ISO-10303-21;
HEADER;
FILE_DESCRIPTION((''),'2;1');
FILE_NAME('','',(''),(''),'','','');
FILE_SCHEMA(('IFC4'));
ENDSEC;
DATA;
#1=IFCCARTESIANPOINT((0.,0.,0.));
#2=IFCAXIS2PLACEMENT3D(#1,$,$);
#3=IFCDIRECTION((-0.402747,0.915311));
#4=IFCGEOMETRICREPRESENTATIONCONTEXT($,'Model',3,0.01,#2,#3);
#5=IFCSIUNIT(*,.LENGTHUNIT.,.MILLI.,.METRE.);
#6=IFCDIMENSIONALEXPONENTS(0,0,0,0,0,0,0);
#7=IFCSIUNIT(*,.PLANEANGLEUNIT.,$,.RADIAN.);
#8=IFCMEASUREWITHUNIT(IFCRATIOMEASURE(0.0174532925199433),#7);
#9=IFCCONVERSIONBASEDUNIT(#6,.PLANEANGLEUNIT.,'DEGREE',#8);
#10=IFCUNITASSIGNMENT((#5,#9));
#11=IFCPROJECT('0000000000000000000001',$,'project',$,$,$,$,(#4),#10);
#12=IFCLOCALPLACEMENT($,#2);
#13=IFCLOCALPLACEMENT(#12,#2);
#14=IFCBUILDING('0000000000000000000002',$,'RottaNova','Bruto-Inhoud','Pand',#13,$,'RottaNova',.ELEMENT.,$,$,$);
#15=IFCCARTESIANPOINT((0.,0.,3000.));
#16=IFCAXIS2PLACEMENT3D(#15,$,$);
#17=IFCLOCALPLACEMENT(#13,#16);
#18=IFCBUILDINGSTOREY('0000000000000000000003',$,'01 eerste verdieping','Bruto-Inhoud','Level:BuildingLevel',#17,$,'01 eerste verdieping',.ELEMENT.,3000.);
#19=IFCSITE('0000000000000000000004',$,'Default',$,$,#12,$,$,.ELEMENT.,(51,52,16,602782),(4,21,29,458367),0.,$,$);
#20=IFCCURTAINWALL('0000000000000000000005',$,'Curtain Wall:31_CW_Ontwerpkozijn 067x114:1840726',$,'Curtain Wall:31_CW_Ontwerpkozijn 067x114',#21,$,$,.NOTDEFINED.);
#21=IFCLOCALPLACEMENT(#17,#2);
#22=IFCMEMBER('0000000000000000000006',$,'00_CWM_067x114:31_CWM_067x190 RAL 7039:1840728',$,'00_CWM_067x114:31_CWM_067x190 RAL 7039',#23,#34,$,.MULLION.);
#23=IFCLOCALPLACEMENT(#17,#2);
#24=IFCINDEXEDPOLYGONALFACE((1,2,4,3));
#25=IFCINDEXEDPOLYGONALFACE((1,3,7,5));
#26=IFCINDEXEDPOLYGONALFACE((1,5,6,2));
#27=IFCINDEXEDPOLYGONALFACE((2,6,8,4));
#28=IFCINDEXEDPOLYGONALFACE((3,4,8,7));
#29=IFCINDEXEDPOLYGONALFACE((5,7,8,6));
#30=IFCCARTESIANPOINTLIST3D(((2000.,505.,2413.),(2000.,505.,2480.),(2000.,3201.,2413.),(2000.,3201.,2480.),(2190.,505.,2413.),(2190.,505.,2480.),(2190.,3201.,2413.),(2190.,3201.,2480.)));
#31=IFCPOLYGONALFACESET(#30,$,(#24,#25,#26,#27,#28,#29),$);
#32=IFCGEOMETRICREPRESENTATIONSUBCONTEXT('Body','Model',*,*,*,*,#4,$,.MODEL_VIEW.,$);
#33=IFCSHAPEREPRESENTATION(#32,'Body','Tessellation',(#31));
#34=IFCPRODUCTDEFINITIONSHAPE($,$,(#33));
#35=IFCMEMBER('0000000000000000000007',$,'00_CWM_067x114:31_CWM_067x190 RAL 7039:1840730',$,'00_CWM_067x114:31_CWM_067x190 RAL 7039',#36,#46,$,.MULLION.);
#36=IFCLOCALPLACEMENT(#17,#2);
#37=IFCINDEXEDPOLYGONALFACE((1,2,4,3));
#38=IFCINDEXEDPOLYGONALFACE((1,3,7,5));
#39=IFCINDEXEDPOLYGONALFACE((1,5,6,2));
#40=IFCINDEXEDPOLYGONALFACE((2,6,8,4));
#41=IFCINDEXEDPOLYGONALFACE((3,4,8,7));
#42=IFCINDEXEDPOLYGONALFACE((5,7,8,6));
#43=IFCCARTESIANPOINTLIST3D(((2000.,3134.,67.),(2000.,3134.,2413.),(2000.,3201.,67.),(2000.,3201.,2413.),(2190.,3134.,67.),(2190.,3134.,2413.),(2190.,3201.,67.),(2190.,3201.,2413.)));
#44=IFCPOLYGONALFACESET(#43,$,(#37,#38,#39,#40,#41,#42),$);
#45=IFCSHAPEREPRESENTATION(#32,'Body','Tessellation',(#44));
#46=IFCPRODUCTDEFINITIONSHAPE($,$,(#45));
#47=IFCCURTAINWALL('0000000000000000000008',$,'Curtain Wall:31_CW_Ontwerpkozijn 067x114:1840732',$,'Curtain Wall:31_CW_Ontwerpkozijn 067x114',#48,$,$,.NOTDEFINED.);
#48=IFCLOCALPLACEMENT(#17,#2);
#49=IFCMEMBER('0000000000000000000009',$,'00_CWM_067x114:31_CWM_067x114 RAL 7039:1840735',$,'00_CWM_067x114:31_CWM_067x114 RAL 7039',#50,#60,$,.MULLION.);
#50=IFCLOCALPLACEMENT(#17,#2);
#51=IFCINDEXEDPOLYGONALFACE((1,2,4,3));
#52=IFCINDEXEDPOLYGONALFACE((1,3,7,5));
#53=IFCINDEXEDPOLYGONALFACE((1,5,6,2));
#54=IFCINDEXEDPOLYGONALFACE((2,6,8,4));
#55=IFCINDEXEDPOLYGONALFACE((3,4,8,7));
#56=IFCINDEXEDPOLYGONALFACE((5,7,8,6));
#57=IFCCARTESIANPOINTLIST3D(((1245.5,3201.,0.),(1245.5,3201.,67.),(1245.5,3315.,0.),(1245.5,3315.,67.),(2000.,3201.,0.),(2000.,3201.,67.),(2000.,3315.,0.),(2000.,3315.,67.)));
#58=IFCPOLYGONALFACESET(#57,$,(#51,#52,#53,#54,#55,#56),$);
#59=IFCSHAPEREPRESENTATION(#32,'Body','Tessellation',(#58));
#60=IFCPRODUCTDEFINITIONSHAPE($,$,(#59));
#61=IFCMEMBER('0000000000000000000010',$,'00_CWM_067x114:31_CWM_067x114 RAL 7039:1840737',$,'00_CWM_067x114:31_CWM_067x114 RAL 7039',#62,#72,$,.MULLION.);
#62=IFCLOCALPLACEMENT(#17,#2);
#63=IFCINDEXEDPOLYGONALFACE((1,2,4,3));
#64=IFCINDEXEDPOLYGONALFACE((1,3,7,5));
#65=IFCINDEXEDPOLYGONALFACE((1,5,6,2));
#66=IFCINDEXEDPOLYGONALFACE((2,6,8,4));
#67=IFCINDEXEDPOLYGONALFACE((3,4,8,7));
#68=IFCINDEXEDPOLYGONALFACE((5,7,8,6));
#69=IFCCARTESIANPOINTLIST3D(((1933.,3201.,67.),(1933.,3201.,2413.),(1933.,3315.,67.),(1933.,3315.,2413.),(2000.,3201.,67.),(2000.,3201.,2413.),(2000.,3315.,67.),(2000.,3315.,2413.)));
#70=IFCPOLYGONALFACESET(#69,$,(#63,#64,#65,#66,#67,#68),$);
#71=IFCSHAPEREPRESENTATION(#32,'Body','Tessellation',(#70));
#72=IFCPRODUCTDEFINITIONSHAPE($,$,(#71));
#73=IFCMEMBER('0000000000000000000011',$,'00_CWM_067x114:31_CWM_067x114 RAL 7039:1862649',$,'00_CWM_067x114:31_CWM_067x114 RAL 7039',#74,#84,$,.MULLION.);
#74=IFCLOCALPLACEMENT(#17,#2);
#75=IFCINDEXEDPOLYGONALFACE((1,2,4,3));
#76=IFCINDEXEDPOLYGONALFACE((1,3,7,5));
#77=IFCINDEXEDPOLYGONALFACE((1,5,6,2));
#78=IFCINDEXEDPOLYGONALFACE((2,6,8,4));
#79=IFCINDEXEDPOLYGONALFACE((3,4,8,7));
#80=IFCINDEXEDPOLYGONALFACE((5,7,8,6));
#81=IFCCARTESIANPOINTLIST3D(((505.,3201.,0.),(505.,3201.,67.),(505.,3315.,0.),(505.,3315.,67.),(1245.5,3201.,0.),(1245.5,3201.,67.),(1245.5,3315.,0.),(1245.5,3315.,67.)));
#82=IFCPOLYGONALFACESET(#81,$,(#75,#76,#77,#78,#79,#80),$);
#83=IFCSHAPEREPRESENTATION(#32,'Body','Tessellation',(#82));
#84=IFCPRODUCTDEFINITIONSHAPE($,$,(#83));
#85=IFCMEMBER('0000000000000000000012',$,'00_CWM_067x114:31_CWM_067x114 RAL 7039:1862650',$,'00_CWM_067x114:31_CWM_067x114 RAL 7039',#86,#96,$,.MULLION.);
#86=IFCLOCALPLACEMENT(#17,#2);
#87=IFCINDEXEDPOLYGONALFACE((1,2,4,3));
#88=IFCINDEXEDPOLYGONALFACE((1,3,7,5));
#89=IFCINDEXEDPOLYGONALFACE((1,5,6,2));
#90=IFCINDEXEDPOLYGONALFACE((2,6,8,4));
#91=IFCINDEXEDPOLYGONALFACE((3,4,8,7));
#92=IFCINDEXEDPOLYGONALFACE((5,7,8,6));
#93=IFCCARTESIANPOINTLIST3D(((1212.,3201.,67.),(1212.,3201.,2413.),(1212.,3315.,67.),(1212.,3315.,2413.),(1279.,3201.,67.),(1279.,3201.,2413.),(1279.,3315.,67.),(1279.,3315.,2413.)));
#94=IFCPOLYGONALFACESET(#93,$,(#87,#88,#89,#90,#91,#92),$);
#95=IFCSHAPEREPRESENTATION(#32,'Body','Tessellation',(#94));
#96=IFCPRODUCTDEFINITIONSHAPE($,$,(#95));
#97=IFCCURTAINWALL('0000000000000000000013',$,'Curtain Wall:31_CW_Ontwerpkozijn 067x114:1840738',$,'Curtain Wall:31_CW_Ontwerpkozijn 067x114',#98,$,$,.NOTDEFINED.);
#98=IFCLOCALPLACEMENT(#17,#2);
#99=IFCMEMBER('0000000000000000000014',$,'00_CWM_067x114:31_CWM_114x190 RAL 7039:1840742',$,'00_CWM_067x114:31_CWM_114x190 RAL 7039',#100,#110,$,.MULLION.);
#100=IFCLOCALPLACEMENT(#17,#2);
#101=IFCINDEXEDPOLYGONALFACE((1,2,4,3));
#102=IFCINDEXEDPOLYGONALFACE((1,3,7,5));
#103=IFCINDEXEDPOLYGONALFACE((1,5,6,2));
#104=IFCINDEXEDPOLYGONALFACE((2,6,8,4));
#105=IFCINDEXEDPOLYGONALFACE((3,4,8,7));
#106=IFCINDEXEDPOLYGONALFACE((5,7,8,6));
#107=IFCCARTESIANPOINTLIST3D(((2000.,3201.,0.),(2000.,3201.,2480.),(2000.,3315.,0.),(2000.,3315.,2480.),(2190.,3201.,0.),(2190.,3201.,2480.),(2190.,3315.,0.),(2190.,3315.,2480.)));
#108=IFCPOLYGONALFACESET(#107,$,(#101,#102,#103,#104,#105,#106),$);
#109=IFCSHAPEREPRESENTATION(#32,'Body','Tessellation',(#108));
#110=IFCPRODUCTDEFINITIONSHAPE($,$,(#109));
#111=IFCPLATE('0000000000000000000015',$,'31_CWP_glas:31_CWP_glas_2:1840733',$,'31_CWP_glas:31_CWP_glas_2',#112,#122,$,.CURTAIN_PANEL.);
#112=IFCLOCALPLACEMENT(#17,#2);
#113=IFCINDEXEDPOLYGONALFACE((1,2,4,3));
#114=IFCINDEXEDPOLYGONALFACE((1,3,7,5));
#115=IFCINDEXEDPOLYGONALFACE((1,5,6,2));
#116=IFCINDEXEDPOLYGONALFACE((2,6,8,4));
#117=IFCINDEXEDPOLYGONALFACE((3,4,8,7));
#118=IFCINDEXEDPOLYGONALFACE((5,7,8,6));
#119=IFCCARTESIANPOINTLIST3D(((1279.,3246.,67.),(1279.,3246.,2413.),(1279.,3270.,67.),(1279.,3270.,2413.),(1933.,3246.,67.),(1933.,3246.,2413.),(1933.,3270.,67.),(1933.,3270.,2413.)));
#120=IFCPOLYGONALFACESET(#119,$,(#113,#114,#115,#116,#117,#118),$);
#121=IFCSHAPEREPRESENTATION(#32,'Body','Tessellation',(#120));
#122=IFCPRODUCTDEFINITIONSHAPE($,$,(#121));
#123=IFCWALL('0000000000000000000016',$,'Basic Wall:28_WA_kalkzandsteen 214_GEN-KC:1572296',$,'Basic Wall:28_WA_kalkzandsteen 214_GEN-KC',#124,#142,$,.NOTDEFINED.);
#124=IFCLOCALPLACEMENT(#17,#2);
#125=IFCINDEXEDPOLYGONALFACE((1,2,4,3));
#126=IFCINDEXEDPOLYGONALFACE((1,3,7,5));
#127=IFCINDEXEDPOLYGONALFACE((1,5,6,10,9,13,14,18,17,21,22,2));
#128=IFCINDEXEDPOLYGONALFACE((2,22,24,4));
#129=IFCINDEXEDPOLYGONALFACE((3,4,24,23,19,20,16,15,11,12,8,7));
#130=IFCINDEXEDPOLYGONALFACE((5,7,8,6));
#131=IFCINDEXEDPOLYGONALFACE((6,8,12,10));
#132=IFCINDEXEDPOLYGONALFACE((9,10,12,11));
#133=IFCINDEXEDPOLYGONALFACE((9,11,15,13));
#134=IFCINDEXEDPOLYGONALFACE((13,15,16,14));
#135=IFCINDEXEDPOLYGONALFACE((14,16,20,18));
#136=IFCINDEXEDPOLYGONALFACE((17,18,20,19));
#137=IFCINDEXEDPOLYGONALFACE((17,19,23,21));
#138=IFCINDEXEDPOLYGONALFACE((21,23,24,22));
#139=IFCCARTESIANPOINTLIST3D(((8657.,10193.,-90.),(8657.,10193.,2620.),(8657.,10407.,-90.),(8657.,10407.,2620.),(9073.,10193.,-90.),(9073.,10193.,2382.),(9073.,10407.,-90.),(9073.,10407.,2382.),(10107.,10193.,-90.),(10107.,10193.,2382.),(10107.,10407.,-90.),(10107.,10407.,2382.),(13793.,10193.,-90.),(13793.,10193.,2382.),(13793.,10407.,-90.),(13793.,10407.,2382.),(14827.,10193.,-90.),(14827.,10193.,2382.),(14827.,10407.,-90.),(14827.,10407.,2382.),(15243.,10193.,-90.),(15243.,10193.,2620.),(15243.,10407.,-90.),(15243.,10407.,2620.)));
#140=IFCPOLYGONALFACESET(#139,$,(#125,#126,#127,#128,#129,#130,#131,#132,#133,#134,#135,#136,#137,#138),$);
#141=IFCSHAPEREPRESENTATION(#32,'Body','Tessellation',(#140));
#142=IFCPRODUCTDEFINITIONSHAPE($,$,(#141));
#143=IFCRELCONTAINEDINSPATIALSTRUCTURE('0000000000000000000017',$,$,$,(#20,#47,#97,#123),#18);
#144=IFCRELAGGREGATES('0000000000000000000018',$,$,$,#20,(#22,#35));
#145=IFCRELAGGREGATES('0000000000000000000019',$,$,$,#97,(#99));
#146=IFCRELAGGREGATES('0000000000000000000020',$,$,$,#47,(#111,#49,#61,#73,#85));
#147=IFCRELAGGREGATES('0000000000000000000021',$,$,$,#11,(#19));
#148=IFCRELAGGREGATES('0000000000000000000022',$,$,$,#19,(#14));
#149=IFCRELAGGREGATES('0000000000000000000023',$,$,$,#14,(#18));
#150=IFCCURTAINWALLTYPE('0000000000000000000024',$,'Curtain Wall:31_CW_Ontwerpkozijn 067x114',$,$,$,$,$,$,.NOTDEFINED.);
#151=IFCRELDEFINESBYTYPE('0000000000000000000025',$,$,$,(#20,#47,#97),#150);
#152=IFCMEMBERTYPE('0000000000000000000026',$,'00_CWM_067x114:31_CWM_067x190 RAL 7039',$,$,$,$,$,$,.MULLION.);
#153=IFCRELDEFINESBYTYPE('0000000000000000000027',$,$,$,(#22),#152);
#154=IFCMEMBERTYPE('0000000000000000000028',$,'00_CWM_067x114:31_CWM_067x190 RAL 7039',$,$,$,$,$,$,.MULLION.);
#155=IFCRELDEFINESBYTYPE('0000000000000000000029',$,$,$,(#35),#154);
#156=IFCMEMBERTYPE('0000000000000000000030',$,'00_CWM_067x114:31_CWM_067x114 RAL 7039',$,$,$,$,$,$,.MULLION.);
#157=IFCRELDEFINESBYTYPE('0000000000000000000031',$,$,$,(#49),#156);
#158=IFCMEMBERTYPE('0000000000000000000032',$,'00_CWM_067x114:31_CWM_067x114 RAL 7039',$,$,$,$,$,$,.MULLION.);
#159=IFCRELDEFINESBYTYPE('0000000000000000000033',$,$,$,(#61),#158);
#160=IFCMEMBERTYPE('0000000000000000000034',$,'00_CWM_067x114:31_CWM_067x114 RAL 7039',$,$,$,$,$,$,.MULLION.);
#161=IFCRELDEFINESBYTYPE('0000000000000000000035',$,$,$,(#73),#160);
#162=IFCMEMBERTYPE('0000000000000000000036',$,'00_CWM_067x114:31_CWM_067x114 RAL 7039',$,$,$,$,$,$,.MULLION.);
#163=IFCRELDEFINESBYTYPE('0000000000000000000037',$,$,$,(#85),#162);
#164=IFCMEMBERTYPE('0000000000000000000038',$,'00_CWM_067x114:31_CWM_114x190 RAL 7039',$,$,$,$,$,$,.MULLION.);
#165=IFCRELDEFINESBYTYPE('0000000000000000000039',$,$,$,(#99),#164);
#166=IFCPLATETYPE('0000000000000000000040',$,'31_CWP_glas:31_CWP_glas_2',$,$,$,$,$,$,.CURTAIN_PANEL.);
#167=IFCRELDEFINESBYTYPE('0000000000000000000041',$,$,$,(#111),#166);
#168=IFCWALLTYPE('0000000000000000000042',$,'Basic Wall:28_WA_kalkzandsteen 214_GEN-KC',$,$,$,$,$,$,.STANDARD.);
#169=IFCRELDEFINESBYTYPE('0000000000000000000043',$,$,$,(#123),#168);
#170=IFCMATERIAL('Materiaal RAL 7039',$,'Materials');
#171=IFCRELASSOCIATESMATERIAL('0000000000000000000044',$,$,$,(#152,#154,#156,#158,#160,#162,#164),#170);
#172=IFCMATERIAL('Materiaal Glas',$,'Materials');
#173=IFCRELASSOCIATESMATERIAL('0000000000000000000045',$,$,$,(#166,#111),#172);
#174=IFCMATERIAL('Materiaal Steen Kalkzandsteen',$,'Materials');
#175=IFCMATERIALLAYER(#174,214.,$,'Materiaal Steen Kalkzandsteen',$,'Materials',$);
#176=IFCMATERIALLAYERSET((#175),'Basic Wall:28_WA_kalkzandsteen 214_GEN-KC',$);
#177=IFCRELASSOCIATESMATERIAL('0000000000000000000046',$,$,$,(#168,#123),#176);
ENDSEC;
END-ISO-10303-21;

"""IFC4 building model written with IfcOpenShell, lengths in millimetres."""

from ifc_helpers import new_model, entity, si_unit, converted_unit, direction, frame, frame_2d, origin, origin_2d_with_axis, place, context, subcontext, project, spatial, rectangle, extrude, source, transform, mapped, material, layer, layer_set, material_profile, profile_set, type_object, type_shapes, element, aggregate, save


model = new_model("IFC4")

# Units and contexts
model_context = context("Model", 3, precision=0.01, world=origin(), true_north=direction((-0.402747, 0.915311)))
body_context = subcontext(model_context, "Body", "Model", "MODEL_VIEW")
ifc_project = project(units=[si_unit("LENGTHUNIT", "METRE", prefix="MILLI"), converted_unit("PLANEANGLEUNIT", "DEGREE", entity("IfcRatioMeasure", 0.0174532925199433), si_unit("PLANEANGLEUNIT", "RADIAN"), dimensions=[0, 0, 0, 0, 0, 0, 0])], contexts=[model_context])

# Site, building, storey
site_placement = place(None, origin())
site = spatial("IfcSite", under=ifc_project, at=site_placement, Name="Default", CompositionType="ELEMENT", RefLatitude=(51, 52, 16, 602782), RefLongitude=(4, 21, 29, 458367), RefElevation=0.0)
building_placement = place(site_placement, origin())
building = spatial("IfcBuilding", under=site, at=building_placement, Name="RottaNova", Description="Bruto-Inhoud", ObjectType="Pand", LongName="RottaNova", CompositionType="ELEMENT")
storey_placement = place(building_placement, frame((0.0, 0.0, 3000.0)))
storey = spatial("IfcBuildingStorey", under=building, at=storey_placement, Name="01 eerste verdieping", Description="Bruto-Inhoud", ObjectType="Level:BuildingLevel", LongName="01 eerste verdieping", CompositionType="ELEMENT", Elevation=3000.0)

# Curtain walls, members
curtain_wall_type = type_object("IfcCurtainWallType", Name="Curtain Wall:31_CW_Ontwerpkozijn 067x114", PredefinedType="NOTDEFINED")
curtain_wall_1_placement = place(storey_placement, frame((0.0, 0.0, -3000.0)))
curtain_wall_1 = element("IfcCurtainWall", 1, at=curtain_wall_1_placement, inside=storey, type_object=curtain_wall_type, Name="Curtain Wall:31_CW_Ontwerpkozijn 067x114:1840726", ObjectType="Curtain Wall:31_CW_Ontwerpkozijn 067x114", PredefinedType="NOTDEFINED")
ifc_material_1 = material(Name="Materiaal RAL 7039", Category="Materials")
ifc_material_profile_1 = material_profile(ifc_material_1, rectangle(XDim=190.0, YDim=67.0, at=origin_2d_with_axis()), Name="31_CWM_067x190 RAL 7039")
ifc_profile_set_1 = profile_set([ifc_material_profile_1], Name="31_CWM_067x190 RAL 7039")
member_type_1 = type_object("IfcMemberType", Name="00_CWM_067x114:31_CWM_067x190 RAL 7039", PredefinedType="MULLION", material=ifc_profile_set_1)
shared_shape_1 = source(origin(), body_context, "Body", "SweptSolid", [
    extrude(rectangle(XDim=190.0, YDim=67.0, at=origin_2d_with_axis()), frame((-33.5, -95.0, -2696.0), z_axis=(0.0, 0.0, 1.0), x_axis=(0.0, -1.0, 0.0)), (0.0, 0.0, 1.0), 2696.0),
])
type_shapes(member_type_1, [shared_shape_1])
member_1_placement = place(curtain_wall_1_placement, frame((2190.0, 3201.0, 5480.0), z_axis=(0.0, 1.0, 0.0), x_axis=(0.0, 0.0, 1.0)))
member_1 = element("IfcMember", 2, at=member_1_placement, type_object=member_type_1, Name="00_CWM_067x114:31_CWM_067x190 RAL 7039:1840728", ObjectType="00_CWM_067x114:31_CWM_067x190 RAL 7039", PredefinedType="MULLION", context=body_context, shape_type="MappedRepresentation", body=[
    mapped(shared_shape_1, transform((0.0, 0.0, 0.0), scale=1.0)),
])
member_type_2 = type_object("IfcMemberType", Name="00_CWM_067x114:31_CWM_067x190 RAL 7039", PredefinedType="MULLION", material=ifc_profile_set_1)
shared_shape_2 = source(origin(), body_context, "Body", "SweptSolid", [
    extrude(rectangle(XDim=190.0, YDim=67.0, at=origin_2d_with_axis()), frame((-33.5, -95.0, -2346.0), z_axis=(0.0, 0.0, 1.0), x_axis=(0.0, -1.0, 0.0)), (0.0, 0.0, 1.0), 2346.0),
])
type_shapes(member_type_2, [shared_shape_2])
member_2_placement = place(curtain_wall_1_placement, frame((2190.0, 3201.0, 3067.0), z_axis=(0.0, 0.0, -1.0), x_axis=(0.0, 1.0, 0.0)))
member_2 = element("IfcMember", 3, at=member_2_placement, type_object=member_type_2, Name="00_CWM_067x114:31_CWM_067x190 RAL 7039:1840730", ObjectType="00_CWM_067x114:31_CWM_067x190 RAL 7039", PredefinedType="MULLION", context=body_context, shape_type="MappedRepresentation", body=[
    mapped(shared_shape_2, transform((0.0, 0.0, 0.0), scale=1.0)),
])
aggregate(curtain_wall_1, [member_1, member_2])
curtain_wall_2_placement = place(storey_placement, frame((0.0, 0.0, -3000.0)))
curtain_wall_2 = element("IfcCurtainWall", 4, at=curtain_wall_2_placement, inside=storey, type_object=curtain_wall_type, Name="Curtain Wall:31_CW_Ontwerpkozijn 067x114:1840732", ObjectType="Curtain Wall:31_CW_Ontwerpkozijn 067x114", PredefinedType="NOTDEFINED")
ifc_material_profile_2 = material_profile(ifc_material_1, rectangle(XDim=114.0, YDim=67.0, at=origin_2d_with_axis()), Name="31_CWM_067x114 RAL 7039")
ifc_profile_set_2 = profile_set([ifc_material_profile_2], Name="31_CWM_067x114 RAL 7039")
member_type_3 = type_object("IfcMemberType", Name="00_CWM_067x114:31_CWM_067x114 RAL 7039", PredefinedType="MULLION", material=ifc_profile_set_2)
shared_shape_3 = source(origin(), body_context, "Body", "SweptSolid", [
    extrude(rectangle(XDim=114.0, YDim=67.0, at=frame_2d((0.0, 0.0), x_axis=(1.0, 0.0))), frame((-33.5, -57.0, -754.5), z_axis=(0.0, 0.0, 1.0), x_axis=(0.0, -1.0, 0.0)), (0.0, 0.0, 1.0), 754.5),
])
type_shapes(member_type_3, [shared_shape_3])
member_3_placement = place(curtain_wall_2_placement, frame((2000.0, 3315.0, 3000.0), z_axis=(1.0, 0.0, 0.0), x_axis=(0.0, 0.0, -1.0)))
member_3 = element("IfcMember", 5, at=member_3_placement, type_object=member_type_3, Name="00_CWM_067x114:31_CWM_067x114 RAL 7039:1840735", ObjectType="00_CWM_067x114:31_CWM_067x114 RAL 7039", PredefinedType="MULLION", context=body_context, shape_type="MappedRepresentation", body=[
    mapped(shared_shape_3, transform((0.0, 0.0, 0.0), scale=1.0)),
])
member_type_4 = type_object("IfcMemberType", Name="00_CWM_067x114:31_CWM_067x114 RAL 7039", PredefinedType="MULLION", material=ifc_profile_set_2)
shared_shape_4 = source(origin(), body_context, "Body", "SweptSolid", [
    extrude(rectangle(XDim=114.0, YDim=67.0, at=frame_2d((0.0, 0.0), x_axis=(1.0, 0.0))), frame((-33.5, -57.0, -2346.0), z_axis=(0.0, 0.0, 1.0), x_axis=(0.0, -1.0, 0.0)), (0.0, 0.0, 1.0), 2346.0),
])
type_shapes(member_type_4, [shared_shape_4])
member_4_placement = place(curtain_wall_2_placement, frame((2000.0, 3315.0, 5413.0)))
member_4 = element("IfcMember", 6, at=member_4_placement, type_object=member_type_4, Name="00_CWM_067x114:31_CWM_067x114 RAL 7039:1840737", ObjectType="00_CWM_067x114:31_CWM_067x114 RAL 7039", PredefinedType="MULLION", context=body_context, shape_type="MappedRepresentation", body=[
    mapped(shared_shape_4, transform((0.0, 0.0, 0.0), scale=1.0)),
])
member_type_5 = type_object("IfcMemberType", Name="00_CWM_067x114:31_CWM_067x114 RAL 7039", PredefinedType="MULLION", material=ifc_profile_set_2)
shared_shape_5 = source(origin(), body_context, "Body", "SweptSolid", [
    extrude(rectangle(XDim=114.0, YDim=67.0, at=frame_2d((0.0, 0.0), x_axis=(1.0, 0.0))), frame((-33.5, -57.0, -740.5), z_axis=(0.0, 0.0, 1.0), x_axis=(0.0, -1.0, 0.0)), (0.0, 0.0, 1.0), 740.5),
])
type_shapes(member_type_5, [shared_shape_5])
member_5_placement = place(curtain_wall_2_placement, frame((1245.5, 3315.0, 3000.0), z_axis=(1.0, 0.0, 0.0), x_axis=(0.0, 0.0, -1.0)))
member_5 = element("IfcMember", 7, at=member_5_placement, type_object=member_type_5, Name="00_CWM_067x114:31_CWM_067x114 RAL 7039:1862649", ObjectType="00_CWM_067x114:31_CWM_067x114 RAL 7039", PredefinedType="MULLION", context=body_context, shape_type="MappedRepresentation", body=[
    mapped(shared_shape_5, transform((0.0, 0.0, 0.0), scale=1.0)),
])
member_type_6 = type_object("IfcMemberType", Name="00_CWM_067x114:31_CWM_067x114 RAL 7039", PredefinedType="MULLION", material=ifc_profile_set_2)
shared_shape_6 = source(origin(), body_context, "Body", "SweptSolid", [
    extrude(rectangle(XDim=114.0, YDim=67.0, at=frame_2d((0.0, 0.0), x_axis=(1.0, 0.0))), frame((0.0, -57.0, -2346.0), z_axis=(0.0, 0.0, 1.0), x_axis=(0.0, -1.0, 0.0)), (0.0, 0.0, 1.0), 2346.0),
])
type_shapes(member_type_6, [shared_shape_6])
member_6_placement = place(curtain_wall_2_placement, frame((1245.5, 3315.0, 3067.0), z_axis=(0.0, 0.0, -1.0), x_axis=(-1.0, 0.0, 0.0)))
member_6 = element("IfcMember", 8, at=member_6_placement, type_object=member_type_6, Name="00_CWM_067x114:31_CWM_067x114 RAL 7039:1862650", ObjectType="00_CWM_067x114:31_CWM_067x114 RAL 7039", PredefinedType="MULLION", context=body_context, shape_type="MappedRepresentation", body=[
    mapped(shared_shape_6, transform((0.0, 0.0, 0.0), scale=1.0)),
])

# Curtain wall, member
curtain_wall_3_placement = place(storey_placement, frame((0.0, 0.0, -3000.0)))
curtain_wall_3 = element("IfcCurtainWall", 9, at=curtain_wall_3_placement, inside=storey, type_object=curtain_wall_type, Name="Curtain Wall:31_CW_Ontwerpkozijn 067x114:1840738", ObjectType="Curtain Wall:31_CW_Ontwerpkozijn 067x114", PredefinedType="NOTDEFINED")
ifc_material_profile_3 = material_profile(ifc_material_1, rectangle(XDim=114.0, YDim=190.0, at=origin_2d_with_axis()), Name="31_CWM_114x190 RAL 7039")
ifc_profile_set_3 = profile_set([ifc_material_profile_3], Name="31_CWM_114x190 RAL 7039")
member_type_7 = type_object("IfcMemberType", Name="00_CWM_067x114:31_CWM_114x190 RAL 7039", PredefinedType="MULLION", material=ifc_profile_set_3)
shared_shape_7 = source(origin(), body_context, "Body", "SweptSolid", [
    extrude(rectangle(XDim=114.0, YDim=190.0, at=origin_2d_with_axis()), frame((-95.0, 0.0, -2480.0), z_axis=(0.0, 0.0, 1.0), x_axis=(0.0, -1.0, 0.0)), (0.0, 0.0, 1.0), 2480.0),
])
type_shapes(member_type_7, [shared_shape_7])
member_7_placement = place(curtain_wall_3_placement, frame((2190.0, 3258.0, 5480.0)))
member_7 = element("IfcMember", 10, at=member_7_placement, type_object=member_type_7, Name="00_CWM_067x114:31_CWM_114x190 RAL 7039:1840742", ObjectType="00_CWM_067x114:31_CWM_114x190 RAL 7039", PredefinedType="MULLION", context=body_context, shape_type="MappedRepresentation", body=[
    mapped(shared_shape_7, transform((0.0, 0.0, 0.0), scale=1.0)),
])
aggregate(curtain_wall_3, [member_7])

# Plate
ifc_material_2 = material(Name="Materiaal Glas", Category="Materials")
plate_type = type_object("IfcPlateType", Name="31_CWP_glas:31_CWP_glas_2", PredefinedType="CURTAIN_PANEL", material=ifc_material_2)
shared_shape_8 = source(origin(), body_context, "Body", "SweptSolid", [
    extrude(rectangle(XDim=24.0, YDim=654.0, at=frame_2d((0.0, 0.0), x_axis=(1.0, 0.0))), frame((327.0, 12.0, 0.0), z_axis=(0.0, 0.0, 1.0), x_axis=(0.0, 1.0, 0.0)), (0.0, 0.0, 1.0), 2346.0),
])
type_shapes(plate_type, [shared_shape_8])
plate_placement = place(curtain_wall_2_placement, frame((1933.0, 3270.0, 3067.0), z_axis=(0.0, 0.0, 1.0), x_axis=(-1.0, 0.0, 0.0)))
plate = element("IfcPlate", 11, at=plate_placement, type_object=plate_type, material=ifc_material_2, Name="31_CWP_glas:31_CWP_glas_2:1840733", ObjectType="31_CWP_glas:31_CWP_glas_2", PredefinedType="CURTAIN_PANEL", context=body_context, shape_type="MappedRepresentation", body=[
    mapped(shared_shape_8, transform((0.0, 0.0, 0.0), scale=1.0)),
])
aggregate(curtain_wall_2, [plate, member_3, member_4, member_5, member_6])

# Wall, openings
ifc_material_3 = material(Name="Materiaal Steen Kalkzandsteen", Category="Materials")
ifc_layer_1 = layer(ifc_material_3, 214.0, Name="Materiaal Steen Kalkzandsteen", Category="Materials")
ifc_layer_set_1 = layer_set([ifc_layer_1], Name="Basic Wall:28_WA_kalkzandsteen 214_GEN-KC")
wall_type_1 = type_object("IfcWallType", Name="Basic Wall:28_WA_kalkzandsteen 214_GEN-KC", PredefinedType="STANDARD", material=ifc_layer_set_1)
wall_1_placement = place(storey_placement, frame((8657.0, 10300.0, -90.0)))
wall_1 = element("IfcWall", 12, at=wall_1_placement, inside=storey, type_object=wall_type_1, material=ifc_layer_set_1, Name="Basic Wall:28_WA_kalkzandsteen 214_GEN-KC:1572296", ObjectType="Basic Wall:28_WA_kalkzandsteen 214_GEN-KC", PredefinedType="NOTDEFINED", context=body_context, shape_type="SweptSolid", body=[
    extrude(rectangle(XDim=6586.0, YDim=214.0, at=frame_2d((3293.0, 0.0), x_axis=(-1.0, 0.0))), origin(), (0.0, 0.0, 1.0), 2710.0),
])
opening_1_placement = place(wall_1_placement, frame((5136.0, -107.0, 0.0)))
element("IfcOpeningElement", 13, at=opening_1_placement, cuts=wall_1, PredefinedType="OPENING", context=body_context, shape_type="SweptSolid", body=[
    extrude(rectangle(XDim=2472.0, YDim=1034.0, at=frame_2d((0.0, 0.0), x_axis=(1.0, 0.0))), frame((517.0, 0.0, 1236.0), z_axis=(0.0, 1.0, 0.0), x_axis=(0.0, 0.0, -1.0)), (0.0, 0.0, 1.0), 214.0),
])
opening_2_placement = place(wall_1_placement, frame((416.0, -107.0, 0.0)))
element("IfcOpeningElement", 14, at=opening_2_placement, cuts=wall_1, PredefinedType="OPENING", context=body_context, shape_type="SweptSolid", body=[
    extrude(rectangle(XDim=2472.0, YDim=1034.0, at=frame_2d((0.0, 0.0), x_axis=(1.0, 0.0))), frame((517.0, 0.0, 1236.0), z_axis=(0.0, 1.0, 0.0), x_axis=(0.0, 0.0, -1.0)), (0.0, 0.0, 1.0), 214.0),
])

save(model, "model.ifc")
